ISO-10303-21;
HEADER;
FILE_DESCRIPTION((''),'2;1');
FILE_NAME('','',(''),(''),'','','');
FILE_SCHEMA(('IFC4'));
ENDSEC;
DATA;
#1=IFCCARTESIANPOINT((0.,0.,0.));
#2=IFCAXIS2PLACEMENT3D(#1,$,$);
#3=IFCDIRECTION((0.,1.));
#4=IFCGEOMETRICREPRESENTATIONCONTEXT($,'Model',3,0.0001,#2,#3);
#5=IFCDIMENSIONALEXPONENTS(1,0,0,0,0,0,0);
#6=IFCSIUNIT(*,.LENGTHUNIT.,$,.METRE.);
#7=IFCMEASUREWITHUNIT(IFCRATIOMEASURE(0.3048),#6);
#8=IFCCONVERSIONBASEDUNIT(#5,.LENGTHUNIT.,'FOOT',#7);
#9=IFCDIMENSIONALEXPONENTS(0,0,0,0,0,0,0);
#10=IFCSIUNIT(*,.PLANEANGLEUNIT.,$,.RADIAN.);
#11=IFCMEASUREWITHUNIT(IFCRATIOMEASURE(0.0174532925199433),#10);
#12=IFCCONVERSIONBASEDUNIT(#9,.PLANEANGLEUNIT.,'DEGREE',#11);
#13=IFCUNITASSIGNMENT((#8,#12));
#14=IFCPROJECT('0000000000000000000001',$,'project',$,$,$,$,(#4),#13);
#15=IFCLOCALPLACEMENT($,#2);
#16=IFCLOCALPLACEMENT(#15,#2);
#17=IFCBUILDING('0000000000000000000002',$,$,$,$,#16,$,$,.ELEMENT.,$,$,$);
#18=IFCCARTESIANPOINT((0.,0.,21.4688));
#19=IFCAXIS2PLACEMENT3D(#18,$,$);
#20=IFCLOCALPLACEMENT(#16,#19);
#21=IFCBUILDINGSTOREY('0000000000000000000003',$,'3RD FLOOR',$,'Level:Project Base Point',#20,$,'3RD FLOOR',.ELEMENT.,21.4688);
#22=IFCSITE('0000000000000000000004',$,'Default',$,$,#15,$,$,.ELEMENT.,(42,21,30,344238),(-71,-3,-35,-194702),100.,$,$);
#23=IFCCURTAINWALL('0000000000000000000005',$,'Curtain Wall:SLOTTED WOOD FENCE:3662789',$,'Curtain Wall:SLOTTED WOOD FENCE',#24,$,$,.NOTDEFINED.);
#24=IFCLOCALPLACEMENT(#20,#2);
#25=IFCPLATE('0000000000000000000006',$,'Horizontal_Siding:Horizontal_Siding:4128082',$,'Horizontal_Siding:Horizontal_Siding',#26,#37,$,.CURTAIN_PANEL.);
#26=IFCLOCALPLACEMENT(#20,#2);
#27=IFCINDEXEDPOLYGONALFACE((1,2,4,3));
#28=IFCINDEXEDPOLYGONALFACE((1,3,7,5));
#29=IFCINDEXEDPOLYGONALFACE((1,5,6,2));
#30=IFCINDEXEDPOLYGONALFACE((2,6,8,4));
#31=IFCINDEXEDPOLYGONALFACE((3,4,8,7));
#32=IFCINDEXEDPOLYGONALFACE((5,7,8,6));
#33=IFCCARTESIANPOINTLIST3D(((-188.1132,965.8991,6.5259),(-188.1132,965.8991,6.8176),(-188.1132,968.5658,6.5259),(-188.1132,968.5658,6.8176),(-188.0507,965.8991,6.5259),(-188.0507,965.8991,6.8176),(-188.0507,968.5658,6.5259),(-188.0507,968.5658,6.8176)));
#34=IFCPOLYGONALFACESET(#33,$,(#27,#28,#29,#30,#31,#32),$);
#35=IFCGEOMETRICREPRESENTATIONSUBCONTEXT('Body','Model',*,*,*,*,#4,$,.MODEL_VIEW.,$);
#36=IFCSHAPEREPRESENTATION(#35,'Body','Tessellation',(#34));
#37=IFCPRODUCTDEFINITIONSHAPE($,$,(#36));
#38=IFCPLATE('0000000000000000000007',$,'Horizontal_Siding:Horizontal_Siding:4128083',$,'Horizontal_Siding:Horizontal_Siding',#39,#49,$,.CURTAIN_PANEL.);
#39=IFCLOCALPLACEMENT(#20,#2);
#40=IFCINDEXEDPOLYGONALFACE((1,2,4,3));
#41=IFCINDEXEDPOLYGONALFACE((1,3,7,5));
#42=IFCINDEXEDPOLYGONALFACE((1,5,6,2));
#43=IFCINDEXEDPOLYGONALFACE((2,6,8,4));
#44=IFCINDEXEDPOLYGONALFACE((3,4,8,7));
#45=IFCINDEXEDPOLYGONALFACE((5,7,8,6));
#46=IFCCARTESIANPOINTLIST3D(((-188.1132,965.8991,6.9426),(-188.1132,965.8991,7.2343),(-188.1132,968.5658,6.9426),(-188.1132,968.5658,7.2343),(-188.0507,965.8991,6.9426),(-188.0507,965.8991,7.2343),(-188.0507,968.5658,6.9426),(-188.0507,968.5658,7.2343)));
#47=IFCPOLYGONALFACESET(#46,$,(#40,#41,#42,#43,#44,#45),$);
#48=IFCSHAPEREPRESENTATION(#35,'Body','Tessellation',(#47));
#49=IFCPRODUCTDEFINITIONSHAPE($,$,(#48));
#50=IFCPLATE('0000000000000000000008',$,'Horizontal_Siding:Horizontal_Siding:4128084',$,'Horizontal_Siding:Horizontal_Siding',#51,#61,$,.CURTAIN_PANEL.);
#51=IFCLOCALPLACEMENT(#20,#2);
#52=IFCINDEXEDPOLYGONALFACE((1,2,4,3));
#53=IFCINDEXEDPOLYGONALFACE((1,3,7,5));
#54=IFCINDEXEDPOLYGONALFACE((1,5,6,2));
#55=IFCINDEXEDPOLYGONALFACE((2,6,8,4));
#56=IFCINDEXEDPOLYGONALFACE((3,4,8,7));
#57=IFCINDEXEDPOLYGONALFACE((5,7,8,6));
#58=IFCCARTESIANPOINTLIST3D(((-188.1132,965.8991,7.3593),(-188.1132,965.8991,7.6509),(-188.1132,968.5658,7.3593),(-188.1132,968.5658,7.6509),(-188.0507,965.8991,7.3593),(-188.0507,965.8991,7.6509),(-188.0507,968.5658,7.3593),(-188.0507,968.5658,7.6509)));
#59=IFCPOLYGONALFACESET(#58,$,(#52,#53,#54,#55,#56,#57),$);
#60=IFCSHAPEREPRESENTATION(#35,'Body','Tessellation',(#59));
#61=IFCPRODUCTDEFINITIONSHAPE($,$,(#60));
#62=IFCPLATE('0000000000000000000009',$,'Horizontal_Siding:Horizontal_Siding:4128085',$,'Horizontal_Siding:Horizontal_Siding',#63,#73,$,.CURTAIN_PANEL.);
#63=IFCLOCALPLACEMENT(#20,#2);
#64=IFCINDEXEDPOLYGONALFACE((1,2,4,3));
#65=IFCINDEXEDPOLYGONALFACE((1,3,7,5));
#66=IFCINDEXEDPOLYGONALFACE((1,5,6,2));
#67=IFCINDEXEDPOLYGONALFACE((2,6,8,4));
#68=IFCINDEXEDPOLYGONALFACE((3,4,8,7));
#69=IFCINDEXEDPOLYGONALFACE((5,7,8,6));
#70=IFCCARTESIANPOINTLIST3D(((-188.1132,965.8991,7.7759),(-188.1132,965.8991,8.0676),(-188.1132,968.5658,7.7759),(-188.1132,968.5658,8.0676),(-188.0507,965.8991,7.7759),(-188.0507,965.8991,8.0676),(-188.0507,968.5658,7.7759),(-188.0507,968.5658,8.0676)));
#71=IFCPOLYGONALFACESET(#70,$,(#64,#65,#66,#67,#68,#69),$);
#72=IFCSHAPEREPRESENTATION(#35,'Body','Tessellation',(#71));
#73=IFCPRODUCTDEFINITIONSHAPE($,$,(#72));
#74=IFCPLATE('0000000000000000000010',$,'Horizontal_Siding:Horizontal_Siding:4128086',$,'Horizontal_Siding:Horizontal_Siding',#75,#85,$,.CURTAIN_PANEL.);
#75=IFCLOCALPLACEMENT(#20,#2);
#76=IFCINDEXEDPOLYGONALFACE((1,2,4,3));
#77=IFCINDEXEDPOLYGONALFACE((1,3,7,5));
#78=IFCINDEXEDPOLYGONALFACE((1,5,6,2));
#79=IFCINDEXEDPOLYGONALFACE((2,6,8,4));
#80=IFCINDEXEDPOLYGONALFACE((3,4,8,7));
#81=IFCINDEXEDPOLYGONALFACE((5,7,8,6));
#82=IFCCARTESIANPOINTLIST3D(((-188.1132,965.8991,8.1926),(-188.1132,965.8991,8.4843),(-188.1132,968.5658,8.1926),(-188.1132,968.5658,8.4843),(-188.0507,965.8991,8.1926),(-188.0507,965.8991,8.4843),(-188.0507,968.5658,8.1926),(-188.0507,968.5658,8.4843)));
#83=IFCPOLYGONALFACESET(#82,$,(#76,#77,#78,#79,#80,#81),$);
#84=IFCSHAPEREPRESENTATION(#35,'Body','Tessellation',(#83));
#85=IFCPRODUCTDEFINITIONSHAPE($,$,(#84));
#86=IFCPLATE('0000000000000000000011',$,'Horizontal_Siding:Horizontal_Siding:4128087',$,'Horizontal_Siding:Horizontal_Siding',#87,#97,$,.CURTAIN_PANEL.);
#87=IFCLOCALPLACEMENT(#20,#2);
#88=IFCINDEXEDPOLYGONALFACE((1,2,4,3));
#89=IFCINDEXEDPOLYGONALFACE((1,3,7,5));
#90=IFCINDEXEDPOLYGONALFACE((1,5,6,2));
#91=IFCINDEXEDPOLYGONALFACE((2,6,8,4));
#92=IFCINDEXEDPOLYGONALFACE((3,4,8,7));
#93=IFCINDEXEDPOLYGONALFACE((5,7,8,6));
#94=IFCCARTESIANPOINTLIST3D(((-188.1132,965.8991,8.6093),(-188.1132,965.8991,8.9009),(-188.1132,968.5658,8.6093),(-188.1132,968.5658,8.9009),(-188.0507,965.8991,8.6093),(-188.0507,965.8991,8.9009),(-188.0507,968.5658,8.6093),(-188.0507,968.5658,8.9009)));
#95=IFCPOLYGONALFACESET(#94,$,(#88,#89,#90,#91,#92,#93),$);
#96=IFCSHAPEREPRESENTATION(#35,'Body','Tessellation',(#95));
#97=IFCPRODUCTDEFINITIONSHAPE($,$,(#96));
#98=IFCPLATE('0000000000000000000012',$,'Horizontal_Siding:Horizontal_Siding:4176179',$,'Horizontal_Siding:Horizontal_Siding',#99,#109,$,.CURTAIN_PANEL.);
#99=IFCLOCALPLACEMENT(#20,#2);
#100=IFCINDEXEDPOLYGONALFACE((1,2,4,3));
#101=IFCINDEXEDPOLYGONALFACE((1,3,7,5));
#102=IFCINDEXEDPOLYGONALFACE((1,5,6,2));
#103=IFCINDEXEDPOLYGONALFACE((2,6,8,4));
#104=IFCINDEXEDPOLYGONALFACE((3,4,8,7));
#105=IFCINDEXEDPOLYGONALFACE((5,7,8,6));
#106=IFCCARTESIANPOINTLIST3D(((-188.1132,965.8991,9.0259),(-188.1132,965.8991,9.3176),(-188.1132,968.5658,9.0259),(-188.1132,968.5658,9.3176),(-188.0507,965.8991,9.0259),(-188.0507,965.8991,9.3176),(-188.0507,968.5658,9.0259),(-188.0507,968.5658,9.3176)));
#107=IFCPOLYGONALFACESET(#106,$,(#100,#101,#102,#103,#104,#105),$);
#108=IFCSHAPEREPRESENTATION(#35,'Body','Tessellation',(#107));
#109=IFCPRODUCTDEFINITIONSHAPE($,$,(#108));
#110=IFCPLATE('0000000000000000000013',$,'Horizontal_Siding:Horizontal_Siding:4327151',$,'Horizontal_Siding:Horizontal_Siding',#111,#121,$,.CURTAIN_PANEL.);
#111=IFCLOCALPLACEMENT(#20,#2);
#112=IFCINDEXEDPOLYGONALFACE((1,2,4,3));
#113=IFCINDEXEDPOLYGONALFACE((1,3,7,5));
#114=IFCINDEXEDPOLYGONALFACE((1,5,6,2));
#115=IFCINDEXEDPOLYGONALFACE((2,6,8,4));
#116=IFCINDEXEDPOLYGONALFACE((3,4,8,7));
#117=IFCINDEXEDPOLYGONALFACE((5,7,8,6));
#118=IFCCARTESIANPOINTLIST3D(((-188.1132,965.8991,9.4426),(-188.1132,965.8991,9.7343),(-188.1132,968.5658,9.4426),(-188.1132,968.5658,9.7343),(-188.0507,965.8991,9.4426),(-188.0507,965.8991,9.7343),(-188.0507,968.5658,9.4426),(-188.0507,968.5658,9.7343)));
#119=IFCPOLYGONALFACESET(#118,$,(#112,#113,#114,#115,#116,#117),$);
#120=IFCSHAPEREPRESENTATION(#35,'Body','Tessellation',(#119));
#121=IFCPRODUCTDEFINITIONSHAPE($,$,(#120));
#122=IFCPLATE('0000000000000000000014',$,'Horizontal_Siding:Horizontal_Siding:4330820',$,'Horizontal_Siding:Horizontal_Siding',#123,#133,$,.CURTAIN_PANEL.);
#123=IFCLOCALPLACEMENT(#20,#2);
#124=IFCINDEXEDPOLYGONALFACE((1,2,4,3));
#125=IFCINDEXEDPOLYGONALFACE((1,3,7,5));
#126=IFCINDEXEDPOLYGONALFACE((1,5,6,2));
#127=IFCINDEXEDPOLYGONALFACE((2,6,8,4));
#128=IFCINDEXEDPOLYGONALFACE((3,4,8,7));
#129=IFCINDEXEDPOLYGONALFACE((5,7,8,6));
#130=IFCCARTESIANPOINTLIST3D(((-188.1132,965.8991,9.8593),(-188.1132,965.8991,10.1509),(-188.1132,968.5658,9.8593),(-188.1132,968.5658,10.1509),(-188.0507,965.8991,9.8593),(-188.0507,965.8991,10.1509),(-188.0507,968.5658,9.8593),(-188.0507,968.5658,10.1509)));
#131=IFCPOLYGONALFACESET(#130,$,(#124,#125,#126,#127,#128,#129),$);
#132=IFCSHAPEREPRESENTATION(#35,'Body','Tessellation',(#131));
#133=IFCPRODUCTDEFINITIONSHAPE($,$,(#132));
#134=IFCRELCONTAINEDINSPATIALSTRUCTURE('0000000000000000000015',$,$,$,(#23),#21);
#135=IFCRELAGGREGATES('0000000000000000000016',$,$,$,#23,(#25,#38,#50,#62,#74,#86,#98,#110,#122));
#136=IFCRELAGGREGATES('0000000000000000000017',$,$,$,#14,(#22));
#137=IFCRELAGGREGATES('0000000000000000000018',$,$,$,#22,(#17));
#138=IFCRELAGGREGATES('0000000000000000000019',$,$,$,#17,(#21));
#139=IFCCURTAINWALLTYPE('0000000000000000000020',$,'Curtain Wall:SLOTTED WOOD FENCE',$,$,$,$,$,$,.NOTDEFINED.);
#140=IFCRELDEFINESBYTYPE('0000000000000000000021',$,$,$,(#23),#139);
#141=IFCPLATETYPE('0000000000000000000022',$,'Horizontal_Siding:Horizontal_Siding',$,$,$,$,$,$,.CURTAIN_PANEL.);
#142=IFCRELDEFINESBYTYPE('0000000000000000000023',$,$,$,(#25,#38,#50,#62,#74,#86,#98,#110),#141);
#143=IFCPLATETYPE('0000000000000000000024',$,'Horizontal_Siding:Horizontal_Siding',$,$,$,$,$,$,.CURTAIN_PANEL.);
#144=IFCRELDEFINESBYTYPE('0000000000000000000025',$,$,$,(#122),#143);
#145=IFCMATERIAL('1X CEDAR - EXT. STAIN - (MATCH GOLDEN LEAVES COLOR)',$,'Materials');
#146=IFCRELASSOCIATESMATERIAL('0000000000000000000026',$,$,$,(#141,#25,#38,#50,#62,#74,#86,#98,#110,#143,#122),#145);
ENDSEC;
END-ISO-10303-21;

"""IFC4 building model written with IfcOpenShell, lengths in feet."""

from ifc_helpers import new_model, entity, si_unit, converted_unit, direction, frame, origin, origin_2d_with_axis, place, context, subcontext, project, spatial, rectangle, extrude, source, transform, mapped, material, type_object, type_shapes, element, aggregate, save


model = new_model("IFC4")

# Units and contexts
model_context = context("Model", 3, precision=0.0001, world=origin(), true_north=direction((0.0, 1.0)))
body_context = subcontext(model_context, "Body", "Model", "MODEL_VIEW")
ifc_project = project(units=[converted_unit("LENGTHUNIT", "FOOT", entity("IfcRatioMeasure", 0.3048), si_unit("LENGTHUNIT", "METRE"), dimensions=[1, 0, 0, 0, 0, 0, 0]), converted_unit("PLANEANGLEUNIT", "DEGREE", entity("IfcRatioMeasure", 0.0174532925199433), si_unit("PLANEANGLEUNIT", "RADIAN"), dimensions=[0, 0, 0, 0, 0, 0, 0])], contexts=[model_context])

# Site, building, storey
site_placement = place(None, origin())
site = spatial("IfcSite", under=ifc_project, at=site_placement, Name="Default", CompositionType="ELEMENT", RefLatitude=(42, 21, 30, 344238), RefLongitude=(-71, -3, -35, -194702), RefElevation=100.0)
building_placement = place(site_placement, origin())
building = spatial("IfcBuilding", under=site, at=building_placement, CompositionType="ELEMENT")
storey_placement = place(building_placement, frame((0.0, 0.0, 21.4688)))
storey = spatial("IfcBuildingStorey", under=building, at=storey_placement, Name="3RD FLOOR", ObjectType="Level:Project Base Point", LongName="3RD FLOOR", CompositionType="ELEMENT", Elevation=21.4688)

# Curtain wall, plates
curtain_wall_type = type_object("IfcCurtainWallType", Name="Curtain Wall:SLOTTED WOOD FENCE", PredefinedType="NOTDEFINED")
curtain_wall_placement = place(storey_placement, frame((0.0, 0.0, -21.4688)))
curtain_wall = element("IfcCurtainWall", 1, at=curtain_wall_placement, inside=storey, type_object=curtain_wall_type, Name="Curtain Wall:SLOTTED WOOD FENCE:3662789", ObjectType="Curtain Wall:SLOTTED WOOD FENCE", PredefinedType="NOTDEFINED")
ifc_material_1 = material(Name="1X CEDAR - EXT. STAIN - (MATCH GOLDEN LEAVES COLOR)", Category="Materials")
plate_type_1 = type_object("IfcPlateType", Name="Horizontal_Siding:Horizontal_Siding", PredefinedType="CURTAIN_PANEL", material=ifc_material_1)
shared_shape_1 = source(origin(), body_context, "Body", "SweptSolid", [
    extrude(rectangle(XDim=0.0625, YDim=2.6667, at=origin_2d_with_axis()), frame((1.3333, 0.0312, 0.0), z_axis=(0.0, 0.0, 1.0), x_axis=(0.0, 1.0, 0.0)), (0.0, 0.0, 1.0), 0.2917),
])
type_shapes(plate_type_1, [shared_shape_1])
plate_1_placement = place(curtain_wall_placement, frame((-188.1132, 968.5658, 27.9947), z_axis=(0.0, 0.0, 1.0), x_axis=(0.0, -1.0, 0.0)))
plate_1 = element("IfcPlate", 2, at=plate_1_placement, type_object=plate_type_1, material=ifc_material_1, Name="Horizontal_Siding:Horizontal_Siding:4128082", ObjectType="Horizontal_Siding:Horizontal_Siding", PredefinedType="CURTAIN_PANEL", context=body_context, shape_type="MappedRepresentation", body=[
    mapped(shared_shape_1, transform((0.0, 0.0, 0.0), scale=1.0)),
])
plate_2_placement = place(curtain_wall_placement, frame((-188.1132, 968.5658, 28.4113), z_axis=(0.0, 0.0, 1.0), x_axis=(0.0, -1.0, 0.0)))
plate_2 = element("IfcPlate", 3, at=plate_2_placement, type_object=plate_type_1, material=ifc_material_1, Name="Horizontal_Siding:Horizontal_Siding:4128083", ObjectType="Horizontal_Siding:Horizontal_Siding", PredefinedType="CURTAIN_PANEL", context=body_context, shape_type="MappedRepresentation", body=[
    mapped(shared_shape_1, transform((0.0, 0.0, 0.0), scale=1.0)),
])
plate_3_placement = place(curtain_wall_placement, frame((-188.1132, 968.5658, 28.828), z_axis=(0.0, 0.0, 1.0), x_axis=(0.0, -1.0, 0.0)))
plate_3 = element("IfcPlate", 4, at=plate_3_placement, type_object=plate_type_1, material=ifc_material_1, Name="Horizontal_Siding:Horizontal_Siding:4128084", ObjectType="Horizontal_Siding:Horizontal_Siding", PredefinedType="CURTAIN_PANEL", context=body_context, shape_type="MappedRepresentation", body=[
    mapped(shared_shape_1, transform((0.0, 0.0, 0.0), scale=1.0)),
])
plate_4_placement = place(curtain_wall_placement, frame((-188.1132, 968.5658, 29.2447), z_axis=(0.0, 0.0, 1.0), x_axis=(0.0, -1.0, 0.0)))
plate_4 = element("IfcPlate", 5, at=plate_4_placement, type_object=plate_type_1, material=ifc_material_1, Name="Horizontal_Siding:Horizontal_Siding:4128085", ObjectType="Horizontal_Siding:Horizontal_Siding", PredefinedType="CURTAIN_PANEL", context=body_context, shape_type="MappedRepresentation", body=[
    mapped(shared_shape_1, transform((0.0, 0.0, 0.0), scale=1.0)),
])
plate_5_placement = place(curtain_wall_placement, frame((-188.1132, 968.5658, 29.6613), z_axis=(0.0, 0.0, 1.0), x_axis=(0.0, -1.0, 0.0)))
plate_5 = element("IfcPlate", 6, at=plate_5_placement, type_object=plate_type_1, material=ifc_material_1, Name="Horizontal_Siding:Horizontal_Siding:4128086", ObjectType="Horizontal_Siding:Horizontal_Siding", PredefinedType="CURTAIN_PANEL", context=body_context, shape_type="MappedRepresentation", body=[
    mapped(shared_shape_1, transform((0.0, 0.0, 0.0), scale=1.0)),
])
plate_6_placement = place(curtain_wall_placement, frame((-188.1132, 968.5658, 30.078), z_axis=(0.0, 0.0, 1.0), x_axis=(0.0, -1.0, 0.0)))
plate_6 = element("IfcPlate", 7, at=plate_6_placement, type_object=plate_type_1, material=ifc_material_1, Name="Horizontal_Siding:Horizontal_Siding:4128087", ObjectType="Horizontal_Siding:Horizontal_Siding", PredefinedType="CURTAIN_PANEL", context=body_context, shape_type="MappedRepresentation", body=[
    mapped(shared_shape_1, transform((0.0, 0.0, 0.0), scale=1.0)),
])
plate_7_placement = place(curtain_wall_placement, frame((-188.1132, 968.5658, 30.4947), z_axis=(0.0, 0.0, 1.0), x_axis=(0.0, -1.0, 0.0)))
plate_7 = element("IfcPlate", 8, at=plate_7_placement, type_object=plate_type_1, material=ifc_material_1, Name="Horizontal_Siding:Horizontal_Siding:4176179", ObjectType="Horizontal_Siding:Horizontal_Siding", PredefinedType="CURTAIN_PANEL", context=body_context, shape_type="MappedRepresentation", body=[
    mapped(shared_shape_1, transform((0.0, 0.0, 0.0), scale=1.0)),
])
plate_8_placement = place(curtain_wall_placement, frame((-188.1132, 968.5658, 30.9113), z_axis=(0.0, 0.0, 1.0), x_axis=(0.0, -1.0, 0.0)))
plate_8 = element("IfcPlate", 9, at=plate_8_placement, type_object=plate_type_1, material=ifc_material_1, Name="Horizontal_Siding:Horizontal_Siding:4327151", ObjectType="Horizontal_Siding:Horizontal_Siding", PredefinedType="CURTAIN_PANEL", context=body_context, shape_type="MappedRepresentation", body=[
    mapped(shared_shape_1, transform((0.0, 0.0, 0.0), scale=1.0)),
])
plate_type_2 = type_object("IfcPlateType", Name="Horizontal_Siding:Horizontal_Siding", PredefinedType="CURTAIN_PANEL", material=ifc_material_1)
shared_shape_2 = source(origin(), body_context, "Body", "SweptSolid", [
    extrude(rectangle(XDim=0.0625, YDim=2.6667, at=origin_2d_with_axis()), frame((1.3333, 0.0312, 0.0), z_axis=(0.0, 0.0, 1.0), x_axis=(0.0, 1.0, 0.0)), (0.0, 0.0, 1.0), 0.2917),
])
type_shapes(plate_type_2, [shared_shape_2])
plate_9_placement = place(curtain_wall_placement, frame((-188.1132, 968.5658, 31.328), z_axis=(0.0, 0.0, 1.0), x_axis=(0.0, -1.0, 0.0)))
plate_9 = element("IfcPlate", 10, at=plate_9_placement, type_object=plate_type_2, material=ifc_material_1, Name="Horizontal_Siding:Horizontal_Siding:4330820", ObjectType="Horizontal_Siding:Horizontal_Siding", PredefinedType="CURTAIN_PANEL", context=body_context, shape_type="MappedRepresentation", body=[
    mapped(shared_shape_2, transform((0.0, 0.0, 0.0), scale=1.0)),
])
aggregate(curtain_wall, [plate_1, plate_2, plate_3, plate_4, plate_5, plate_6, plate_7, plate_8, plate_9])

save(model, "model.ifc")
